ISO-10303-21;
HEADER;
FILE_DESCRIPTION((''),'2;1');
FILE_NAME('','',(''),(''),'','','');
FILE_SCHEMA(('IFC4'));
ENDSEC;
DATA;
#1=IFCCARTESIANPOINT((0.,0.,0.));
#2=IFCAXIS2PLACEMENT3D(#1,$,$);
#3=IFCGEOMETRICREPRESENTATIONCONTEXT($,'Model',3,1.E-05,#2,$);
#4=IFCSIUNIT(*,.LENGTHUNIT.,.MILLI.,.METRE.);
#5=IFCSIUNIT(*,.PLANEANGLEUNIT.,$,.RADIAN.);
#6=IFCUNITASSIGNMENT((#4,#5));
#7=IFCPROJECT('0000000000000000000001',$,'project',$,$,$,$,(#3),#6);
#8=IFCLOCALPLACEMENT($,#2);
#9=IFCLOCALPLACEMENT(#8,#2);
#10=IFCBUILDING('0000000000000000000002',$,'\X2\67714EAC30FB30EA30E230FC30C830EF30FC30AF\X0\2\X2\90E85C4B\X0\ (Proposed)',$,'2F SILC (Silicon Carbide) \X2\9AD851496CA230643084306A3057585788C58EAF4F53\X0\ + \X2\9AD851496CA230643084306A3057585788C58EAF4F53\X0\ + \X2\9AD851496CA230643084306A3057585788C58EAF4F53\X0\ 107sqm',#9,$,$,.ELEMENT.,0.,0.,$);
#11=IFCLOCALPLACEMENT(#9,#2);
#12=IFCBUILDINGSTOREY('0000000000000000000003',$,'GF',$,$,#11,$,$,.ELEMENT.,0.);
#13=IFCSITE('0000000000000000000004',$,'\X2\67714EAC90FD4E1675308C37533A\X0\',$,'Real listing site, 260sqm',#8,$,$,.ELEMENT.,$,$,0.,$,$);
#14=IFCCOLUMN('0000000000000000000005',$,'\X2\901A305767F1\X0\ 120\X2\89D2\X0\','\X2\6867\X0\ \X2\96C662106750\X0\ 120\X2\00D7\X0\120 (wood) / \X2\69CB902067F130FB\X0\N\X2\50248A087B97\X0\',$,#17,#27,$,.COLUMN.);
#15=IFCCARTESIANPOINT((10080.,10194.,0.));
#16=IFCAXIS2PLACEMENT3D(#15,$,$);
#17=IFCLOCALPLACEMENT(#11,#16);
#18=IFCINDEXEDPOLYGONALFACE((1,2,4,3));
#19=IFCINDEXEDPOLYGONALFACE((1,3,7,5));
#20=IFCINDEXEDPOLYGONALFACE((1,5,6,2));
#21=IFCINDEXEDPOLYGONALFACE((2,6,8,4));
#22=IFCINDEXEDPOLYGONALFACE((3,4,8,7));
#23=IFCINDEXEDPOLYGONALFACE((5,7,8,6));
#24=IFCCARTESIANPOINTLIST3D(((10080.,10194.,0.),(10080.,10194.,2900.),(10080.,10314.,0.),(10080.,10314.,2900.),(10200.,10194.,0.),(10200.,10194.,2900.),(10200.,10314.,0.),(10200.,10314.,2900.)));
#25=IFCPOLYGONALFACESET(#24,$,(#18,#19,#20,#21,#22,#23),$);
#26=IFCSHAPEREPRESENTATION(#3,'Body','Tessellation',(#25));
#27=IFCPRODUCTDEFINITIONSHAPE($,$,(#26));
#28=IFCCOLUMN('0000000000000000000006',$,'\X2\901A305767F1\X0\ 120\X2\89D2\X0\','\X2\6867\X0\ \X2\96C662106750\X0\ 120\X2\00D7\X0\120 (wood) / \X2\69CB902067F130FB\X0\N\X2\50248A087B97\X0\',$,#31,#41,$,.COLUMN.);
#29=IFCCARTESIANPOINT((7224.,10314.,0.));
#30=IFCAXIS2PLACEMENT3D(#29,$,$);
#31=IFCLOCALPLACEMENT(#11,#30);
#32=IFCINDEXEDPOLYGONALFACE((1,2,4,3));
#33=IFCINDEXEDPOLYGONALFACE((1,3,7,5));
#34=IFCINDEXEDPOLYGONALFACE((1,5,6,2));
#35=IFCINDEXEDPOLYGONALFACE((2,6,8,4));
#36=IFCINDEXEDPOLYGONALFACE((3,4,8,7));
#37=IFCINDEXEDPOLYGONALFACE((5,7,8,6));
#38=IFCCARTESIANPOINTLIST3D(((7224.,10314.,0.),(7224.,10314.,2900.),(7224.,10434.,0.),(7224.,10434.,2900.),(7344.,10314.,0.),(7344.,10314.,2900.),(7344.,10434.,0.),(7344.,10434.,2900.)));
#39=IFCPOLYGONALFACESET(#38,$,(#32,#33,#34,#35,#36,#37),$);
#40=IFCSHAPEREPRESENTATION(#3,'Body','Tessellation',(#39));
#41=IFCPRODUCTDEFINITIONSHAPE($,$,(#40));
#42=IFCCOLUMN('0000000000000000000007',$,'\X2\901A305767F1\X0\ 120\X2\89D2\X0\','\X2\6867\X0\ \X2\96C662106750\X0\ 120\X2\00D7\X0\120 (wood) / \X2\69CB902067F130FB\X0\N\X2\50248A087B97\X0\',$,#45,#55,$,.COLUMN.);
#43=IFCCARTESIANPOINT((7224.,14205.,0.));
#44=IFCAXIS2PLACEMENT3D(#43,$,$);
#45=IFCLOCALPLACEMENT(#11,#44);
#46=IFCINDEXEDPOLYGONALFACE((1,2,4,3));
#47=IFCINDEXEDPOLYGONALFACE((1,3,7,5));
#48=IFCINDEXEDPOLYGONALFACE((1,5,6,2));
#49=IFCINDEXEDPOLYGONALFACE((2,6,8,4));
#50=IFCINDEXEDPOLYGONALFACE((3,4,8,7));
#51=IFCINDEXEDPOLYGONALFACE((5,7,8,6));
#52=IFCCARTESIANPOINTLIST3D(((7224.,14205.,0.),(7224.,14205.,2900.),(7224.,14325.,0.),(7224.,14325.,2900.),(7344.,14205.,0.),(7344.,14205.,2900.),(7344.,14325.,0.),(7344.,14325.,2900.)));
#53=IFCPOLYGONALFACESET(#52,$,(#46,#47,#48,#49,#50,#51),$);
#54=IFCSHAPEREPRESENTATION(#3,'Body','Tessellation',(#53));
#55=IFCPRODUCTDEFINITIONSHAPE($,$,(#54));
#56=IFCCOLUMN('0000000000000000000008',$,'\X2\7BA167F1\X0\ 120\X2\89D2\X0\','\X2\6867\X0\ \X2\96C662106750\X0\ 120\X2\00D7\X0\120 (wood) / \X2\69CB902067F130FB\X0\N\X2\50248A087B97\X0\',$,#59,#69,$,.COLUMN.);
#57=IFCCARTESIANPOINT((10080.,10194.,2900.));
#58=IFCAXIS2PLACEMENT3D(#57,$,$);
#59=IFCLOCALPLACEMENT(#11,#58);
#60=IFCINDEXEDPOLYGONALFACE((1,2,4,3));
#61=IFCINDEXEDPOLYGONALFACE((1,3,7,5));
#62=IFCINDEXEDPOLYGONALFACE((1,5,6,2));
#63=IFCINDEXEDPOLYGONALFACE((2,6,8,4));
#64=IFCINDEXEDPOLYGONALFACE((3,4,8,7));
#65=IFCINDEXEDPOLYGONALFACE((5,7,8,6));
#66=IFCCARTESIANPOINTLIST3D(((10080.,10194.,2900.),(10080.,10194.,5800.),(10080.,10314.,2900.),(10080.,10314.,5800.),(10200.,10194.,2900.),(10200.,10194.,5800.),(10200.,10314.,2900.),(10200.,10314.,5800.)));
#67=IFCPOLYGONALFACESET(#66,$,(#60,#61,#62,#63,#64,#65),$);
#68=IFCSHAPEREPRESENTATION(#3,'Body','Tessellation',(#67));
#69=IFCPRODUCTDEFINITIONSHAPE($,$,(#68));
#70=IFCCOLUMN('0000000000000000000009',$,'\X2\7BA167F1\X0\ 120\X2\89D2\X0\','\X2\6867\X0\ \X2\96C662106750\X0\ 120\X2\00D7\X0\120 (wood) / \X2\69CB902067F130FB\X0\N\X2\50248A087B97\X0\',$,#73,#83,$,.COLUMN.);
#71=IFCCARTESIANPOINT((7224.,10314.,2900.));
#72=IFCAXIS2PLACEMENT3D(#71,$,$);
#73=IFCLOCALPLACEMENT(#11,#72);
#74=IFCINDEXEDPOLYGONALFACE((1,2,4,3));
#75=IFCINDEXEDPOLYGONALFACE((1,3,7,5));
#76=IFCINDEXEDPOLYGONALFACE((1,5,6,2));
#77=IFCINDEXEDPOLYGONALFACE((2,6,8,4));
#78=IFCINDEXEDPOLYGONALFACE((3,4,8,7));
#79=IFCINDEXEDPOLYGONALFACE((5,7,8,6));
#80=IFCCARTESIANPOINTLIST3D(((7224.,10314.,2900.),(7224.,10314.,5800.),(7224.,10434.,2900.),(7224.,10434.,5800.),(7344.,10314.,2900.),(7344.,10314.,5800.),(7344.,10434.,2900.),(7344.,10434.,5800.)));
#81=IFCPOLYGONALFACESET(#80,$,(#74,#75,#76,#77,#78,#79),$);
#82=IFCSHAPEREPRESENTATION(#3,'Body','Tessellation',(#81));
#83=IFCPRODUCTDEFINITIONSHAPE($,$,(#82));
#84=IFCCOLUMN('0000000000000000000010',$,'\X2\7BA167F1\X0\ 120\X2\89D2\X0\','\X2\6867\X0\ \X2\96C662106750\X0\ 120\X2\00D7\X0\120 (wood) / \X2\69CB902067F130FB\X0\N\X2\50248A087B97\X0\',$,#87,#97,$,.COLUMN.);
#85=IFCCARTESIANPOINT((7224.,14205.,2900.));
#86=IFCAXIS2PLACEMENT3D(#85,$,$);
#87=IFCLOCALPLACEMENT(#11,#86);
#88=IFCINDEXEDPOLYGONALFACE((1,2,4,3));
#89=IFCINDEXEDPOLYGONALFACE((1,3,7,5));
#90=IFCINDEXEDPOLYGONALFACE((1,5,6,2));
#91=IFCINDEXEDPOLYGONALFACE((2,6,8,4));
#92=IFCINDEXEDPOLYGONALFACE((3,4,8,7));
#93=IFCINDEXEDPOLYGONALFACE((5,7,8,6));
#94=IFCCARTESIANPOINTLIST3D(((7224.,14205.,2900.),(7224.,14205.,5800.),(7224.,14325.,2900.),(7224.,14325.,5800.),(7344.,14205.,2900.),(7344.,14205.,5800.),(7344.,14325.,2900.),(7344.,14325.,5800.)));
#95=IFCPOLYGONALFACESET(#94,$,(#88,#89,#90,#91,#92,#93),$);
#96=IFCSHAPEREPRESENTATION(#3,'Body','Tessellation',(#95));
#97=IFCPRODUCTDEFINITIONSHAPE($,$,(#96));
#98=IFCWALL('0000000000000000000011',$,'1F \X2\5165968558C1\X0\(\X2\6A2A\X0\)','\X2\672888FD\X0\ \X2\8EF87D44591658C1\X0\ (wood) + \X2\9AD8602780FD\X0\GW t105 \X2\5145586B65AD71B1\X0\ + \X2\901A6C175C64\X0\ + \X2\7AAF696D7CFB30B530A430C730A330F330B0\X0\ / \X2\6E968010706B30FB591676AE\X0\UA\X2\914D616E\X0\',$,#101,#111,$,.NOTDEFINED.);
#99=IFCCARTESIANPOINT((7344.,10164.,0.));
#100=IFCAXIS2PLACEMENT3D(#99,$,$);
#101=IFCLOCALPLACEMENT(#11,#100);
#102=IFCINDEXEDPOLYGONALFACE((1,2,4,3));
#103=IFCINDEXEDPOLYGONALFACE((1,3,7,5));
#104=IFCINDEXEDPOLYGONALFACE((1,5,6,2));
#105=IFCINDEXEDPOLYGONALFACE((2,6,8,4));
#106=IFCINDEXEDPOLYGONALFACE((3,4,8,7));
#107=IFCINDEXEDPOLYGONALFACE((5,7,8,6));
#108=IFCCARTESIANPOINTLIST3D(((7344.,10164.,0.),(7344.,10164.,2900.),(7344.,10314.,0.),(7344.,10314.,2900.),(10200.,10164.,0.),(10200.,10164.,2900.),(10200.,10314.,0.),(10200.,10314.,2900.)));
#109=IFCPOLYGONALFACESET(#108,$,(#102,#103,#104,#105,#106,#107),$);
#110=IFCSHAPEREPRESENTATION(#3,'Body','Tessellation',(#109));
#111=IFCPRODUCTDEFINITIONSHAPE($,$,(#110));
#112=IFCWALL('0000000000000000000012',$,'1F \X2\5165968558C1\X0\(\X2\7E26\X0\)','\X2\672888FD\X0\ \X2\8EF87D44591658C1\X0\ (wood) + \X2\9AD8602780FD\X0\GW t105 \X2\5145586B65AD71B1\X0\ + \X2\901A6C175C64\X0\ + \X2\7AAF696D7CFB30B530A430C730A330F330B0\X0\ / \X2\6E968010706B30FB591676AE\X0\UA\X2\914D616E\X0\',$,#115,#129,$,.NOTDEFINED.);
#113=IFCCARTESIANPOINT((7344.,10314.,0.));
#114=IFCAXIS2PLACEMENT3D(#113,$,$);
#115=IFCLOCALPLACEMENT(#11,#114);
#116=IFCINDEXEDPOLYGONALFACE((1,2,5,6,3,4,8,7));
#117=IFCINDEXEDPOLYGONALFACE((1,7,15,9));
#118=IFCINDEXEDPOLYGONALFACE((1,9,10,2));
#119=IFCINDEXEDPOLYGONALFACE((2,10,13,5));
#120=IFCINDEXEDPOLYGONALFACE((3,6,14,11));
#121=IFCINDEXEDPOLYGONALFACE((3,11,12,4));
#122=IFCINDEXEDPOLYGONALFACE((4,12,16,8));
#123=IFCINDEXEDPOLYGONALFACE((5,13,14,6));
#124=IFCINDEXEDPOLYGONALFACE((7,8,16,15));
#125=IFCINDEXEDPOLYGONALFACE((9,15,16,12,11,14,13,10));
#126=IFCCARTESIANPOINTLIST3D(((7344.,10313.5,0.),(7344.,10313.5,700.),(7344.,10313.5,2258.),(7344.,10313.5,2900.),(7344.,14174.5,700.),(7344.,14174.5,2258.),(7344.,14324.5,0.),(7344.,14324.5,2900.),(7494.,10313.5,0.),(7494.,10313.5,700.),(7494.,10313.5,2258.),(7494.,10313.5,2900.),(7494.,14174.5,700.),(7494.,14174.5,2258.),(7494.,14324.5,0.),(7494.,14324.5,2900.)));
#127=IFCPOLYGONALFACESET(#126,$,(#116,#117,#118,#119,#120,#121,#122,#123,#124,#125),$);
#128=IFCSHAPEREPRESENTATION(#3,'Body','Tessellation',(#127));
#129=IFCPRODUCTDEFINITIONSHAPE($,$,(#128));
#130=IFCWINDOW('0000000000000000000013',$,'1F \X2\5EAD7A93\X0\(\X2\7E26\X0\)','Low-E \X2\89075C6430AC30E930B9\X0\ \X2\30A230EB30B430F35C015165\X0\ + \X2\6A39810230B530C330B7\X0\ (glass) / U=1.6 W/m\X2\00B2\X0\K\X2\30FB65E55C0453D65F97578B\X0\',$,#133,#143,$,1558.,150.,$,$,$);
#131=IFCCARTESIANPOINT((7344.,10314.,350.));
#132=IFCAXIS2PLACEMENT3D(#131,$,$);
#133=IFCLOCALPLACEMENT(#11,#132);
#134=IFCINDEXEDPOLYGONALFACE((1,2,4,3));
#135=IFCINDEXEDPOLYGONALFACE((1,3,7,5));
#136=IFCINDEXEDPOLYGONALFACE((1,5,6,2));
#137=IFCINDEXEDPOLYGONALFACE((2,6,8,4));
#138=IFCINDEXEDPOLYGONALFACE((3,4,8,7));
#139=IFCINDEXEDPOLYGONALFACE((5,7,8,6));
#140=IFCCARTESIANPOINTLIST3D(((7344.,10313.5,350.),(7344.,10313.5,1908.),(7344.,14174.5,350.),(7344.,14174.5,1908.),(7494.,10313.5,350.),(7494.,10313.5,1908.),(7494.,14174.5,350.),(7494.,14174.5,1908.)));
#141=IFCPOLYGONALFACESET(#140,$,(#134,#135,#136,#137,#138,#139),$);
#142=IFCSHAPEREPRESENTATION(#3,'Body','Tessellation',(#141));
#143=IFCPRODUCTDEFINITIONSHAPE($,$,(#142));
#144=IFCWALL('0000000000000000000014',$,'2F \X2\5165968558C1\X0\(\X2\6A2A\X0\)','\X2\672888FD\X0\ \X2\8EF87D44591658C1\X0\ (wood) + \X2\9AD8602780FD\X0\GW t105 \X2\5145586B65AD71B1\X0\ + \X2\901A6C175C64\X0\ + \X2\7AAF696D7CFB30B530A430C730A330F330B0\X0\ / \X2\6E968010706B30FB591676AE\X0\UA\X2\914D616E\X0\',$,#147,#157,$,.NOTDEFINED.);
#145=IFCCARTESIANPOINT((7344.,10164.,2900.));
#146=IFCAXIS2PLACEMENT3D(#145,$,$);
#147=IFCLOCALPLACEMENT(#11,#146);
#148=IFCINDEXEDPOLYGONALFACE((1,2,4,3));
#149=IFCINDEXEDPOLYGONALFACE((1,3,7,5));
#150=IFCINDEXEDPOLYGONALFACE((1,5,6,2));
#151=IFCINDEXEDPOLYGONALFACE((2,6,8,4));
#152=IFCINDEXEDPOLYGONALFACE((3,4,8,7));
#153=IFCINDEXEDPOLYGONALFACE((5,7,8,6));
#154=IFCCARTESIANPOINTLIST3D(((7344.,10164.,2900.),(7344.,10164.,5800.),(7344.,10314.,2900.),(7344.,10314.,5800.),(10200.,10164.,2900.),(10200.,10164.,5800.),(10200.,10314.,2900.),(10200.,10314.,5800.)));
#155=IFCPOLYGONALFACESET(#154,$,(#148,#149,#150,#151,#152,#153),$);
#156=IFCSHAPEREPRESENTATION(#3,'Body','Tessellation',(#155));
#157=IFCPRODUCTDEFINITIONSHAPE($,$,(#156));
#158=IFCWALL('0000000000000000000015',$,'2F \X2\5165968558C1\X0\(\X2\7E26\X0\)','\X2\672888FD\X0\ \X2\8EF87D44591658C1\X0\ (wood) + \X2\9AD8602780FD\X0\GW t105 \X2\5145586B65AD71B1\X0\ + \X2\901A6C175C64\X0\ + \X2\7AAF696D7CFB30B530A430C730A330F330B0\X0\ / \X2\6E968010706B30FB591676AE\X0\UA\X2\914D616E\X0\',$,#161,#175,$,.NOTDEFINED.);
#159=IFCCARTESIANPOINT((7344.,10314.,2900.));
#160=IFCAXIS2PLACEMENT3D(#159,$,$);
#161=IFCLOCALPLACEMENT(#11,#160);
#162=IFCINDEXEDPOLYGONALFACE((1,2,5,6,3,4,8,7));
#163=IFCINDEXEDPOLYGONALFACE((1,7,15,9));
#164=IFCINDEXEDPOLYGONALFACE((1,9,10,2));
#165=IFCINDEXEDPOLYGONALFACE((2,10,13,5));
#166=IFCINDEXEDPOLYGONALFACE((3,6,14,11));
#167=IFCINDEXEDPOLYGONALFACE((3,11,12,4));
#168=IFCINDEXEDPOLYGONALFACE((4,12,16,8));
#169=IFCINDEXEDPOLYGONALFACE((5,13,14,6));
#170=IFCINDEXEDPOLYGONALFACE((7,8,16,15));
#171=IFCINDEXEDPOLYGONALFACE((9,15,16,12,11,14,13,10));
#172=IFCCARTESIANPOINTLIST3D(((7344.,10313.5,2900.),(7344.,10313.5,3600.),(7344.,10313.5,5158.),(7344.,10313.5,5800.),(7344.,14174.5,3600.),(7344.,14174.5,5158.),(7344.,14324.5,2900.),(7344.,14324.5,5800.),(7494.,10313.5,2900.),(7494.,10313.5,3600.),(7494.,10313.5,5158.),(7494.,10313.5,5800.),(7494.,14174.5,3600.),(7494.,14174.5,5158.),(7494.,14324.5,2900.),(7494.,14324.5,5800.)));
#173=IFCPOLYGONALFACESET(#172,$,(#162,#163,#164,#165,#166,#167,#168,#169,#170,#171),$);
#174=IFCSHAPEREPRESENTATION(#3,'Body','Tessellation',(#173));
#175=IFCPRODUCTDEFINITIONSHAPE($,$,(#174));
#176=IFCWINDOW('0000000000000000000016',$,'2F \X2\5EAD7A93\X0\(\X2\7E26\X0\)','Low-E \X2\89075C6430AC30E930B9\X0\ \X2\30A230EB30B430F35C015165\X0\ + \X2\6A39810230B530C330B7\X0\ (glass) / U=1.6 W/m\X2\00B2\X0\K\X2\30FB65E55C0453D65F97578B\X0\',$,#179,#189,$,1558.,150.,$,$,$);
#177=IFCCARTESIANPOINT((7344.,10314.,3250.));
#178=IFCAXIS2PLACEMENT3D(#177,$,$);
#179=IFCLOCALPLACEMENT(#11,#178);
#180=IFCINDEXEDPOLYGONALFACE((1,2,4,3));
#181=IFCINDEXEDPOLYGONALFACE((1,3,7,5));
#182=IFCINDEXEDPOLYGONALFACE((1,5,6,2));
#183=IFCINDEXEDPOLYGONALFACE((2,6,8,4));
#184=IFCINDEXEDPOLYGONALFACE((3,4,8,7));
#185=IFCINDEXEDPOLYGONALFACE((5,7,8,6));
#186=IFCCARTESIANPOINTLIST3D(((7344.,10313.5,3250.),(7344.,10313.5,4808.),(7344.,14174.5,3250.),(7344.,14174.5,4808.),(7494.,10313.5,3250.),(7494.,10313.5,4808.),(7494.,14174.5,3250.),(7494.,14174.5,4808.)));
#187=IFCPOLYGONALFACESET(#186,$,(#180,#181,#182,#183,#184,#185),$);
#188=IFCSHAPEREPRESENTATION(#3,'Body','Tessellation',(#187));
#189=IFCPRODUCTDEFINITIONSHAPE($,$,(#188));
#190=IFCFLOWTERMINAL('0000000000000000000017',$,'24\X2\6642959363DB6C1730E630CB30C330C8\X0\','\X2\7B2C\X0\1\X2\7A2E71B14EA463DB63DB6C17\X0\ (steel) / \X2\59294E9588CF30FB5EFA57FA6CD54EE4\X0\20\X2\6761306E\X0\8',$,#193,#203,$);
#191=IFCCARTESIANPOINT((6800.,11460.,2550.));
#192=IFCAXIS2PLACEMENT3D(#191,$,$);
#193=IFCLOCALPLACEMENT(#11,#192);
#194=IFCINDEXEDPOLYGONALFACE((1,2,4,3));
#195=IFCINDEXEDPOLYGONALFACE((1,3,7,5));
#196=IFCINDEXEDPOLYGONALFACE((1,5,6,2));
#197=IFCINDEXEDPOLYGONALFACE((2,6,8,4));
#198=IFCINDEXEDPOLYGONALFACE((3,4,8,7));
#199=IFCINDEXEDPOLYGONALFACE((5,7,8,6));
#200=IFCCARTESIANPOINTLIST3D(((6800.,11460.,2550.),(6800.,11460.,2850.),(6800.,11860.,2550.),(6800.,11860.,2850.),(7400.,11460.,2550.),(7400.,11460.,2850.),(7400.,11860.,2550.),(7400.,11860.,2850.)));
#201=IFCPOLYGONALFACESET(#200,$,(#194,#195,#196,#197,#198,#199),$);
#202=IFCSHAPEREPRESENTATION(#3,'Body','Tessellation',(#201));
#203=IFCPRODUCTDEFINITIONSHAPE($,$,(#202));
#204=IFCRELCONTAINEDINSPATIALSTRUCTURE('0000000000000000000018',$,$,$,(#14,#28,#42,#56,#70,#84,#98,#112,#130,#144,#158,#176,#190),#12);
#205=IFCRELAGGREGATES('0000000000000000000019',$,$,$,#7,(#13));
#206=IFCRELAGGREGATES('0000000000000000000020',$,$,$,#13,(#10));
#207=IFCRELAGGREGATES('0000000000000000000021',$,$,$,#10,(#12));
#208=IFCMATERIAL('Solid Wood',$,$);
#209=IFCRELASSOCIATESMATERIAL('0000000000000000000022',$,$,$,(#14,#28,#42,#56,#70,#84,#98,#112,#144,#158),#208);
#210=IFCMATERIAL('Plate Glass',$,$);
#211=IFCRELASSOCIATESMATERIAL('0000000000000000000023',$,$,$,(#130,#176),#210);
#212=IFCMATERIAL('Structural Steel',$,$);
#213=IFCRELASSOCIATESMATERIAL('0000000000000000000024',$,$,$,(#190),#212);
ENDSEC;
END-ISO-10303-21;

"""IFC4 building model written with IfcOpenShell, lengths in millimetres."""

from ifc_helpers import new_model, si_unit, frame, frame_2d, origin, place, context, project, spatial, rectangle, extrude, material, element, fill, save


model = new_model("IFC4")

# Units and contexts
model_context = context("Model", 3, precision=1e-05, world=origin())
ifc_project = project(units=[si_unit("LENGTHUNIT", "METRE", prefix="MILLI"), si_unit("PLANEANGLEUNIT", "RADIAN")], contexts=[model_context])

# Site, building, storey
site_placement = place(None, origin())
site = spatial("IfcSite", under=ifc_project, at=site_placement, Name="東京都世田谷区", ObjectType="Real listing site, 260sqm", CompositionType="ELEMENT", RefElevation=0.0)
building_placement = place(site_placement, origin())
building = spatial("IfcBuilding", under=site, at=building_placement, Name="東京・リモートワーク2部屋 (Proposed)", ObjectType="2F SILC (Silicon Carbide) 高光沢つやなし塗装躯体 + 高光沢つやなし塗装躯体 + 高光沢つやなし塗装躯体 107sqm", CompositionType="ELEMENT", ElevationOfRefHeight=0.0, ElevationOfTerrain=0.0)
storey_placement = place(building_placement, origin())
storey = spatial("IfcBuildingStorey", under=building, at=storey_placement, Name="GF", CompositionType="ELEMENT", Elevation=0.0)

# Columns
ifc_material_1 = material(Name="Solid Wood")
column_1_placement = place(storey_placement, frame((10080.0, 10194.0, 0.0)))
element("IfcColumn", 1, at=column_1_placement, inside=storey, material=ifc_material_1, Name="通し柱 120角", Description="桧 集成材 120×120 (wood) / 構造柱・N値計算", PredefinedType="COLUMN", context=model_context, shape_type="SweptSolid", body=[
    extrude(rectangle(XDim=120.0, YDim=120.0, at=frame_2d((60.0, 60.0))), frame((10080.0, 10194.0, 0.0)), (0.0, 0.0, 1.0), 2900.0),
])
column_2_placement = place(storey_placement, frame((7224.0, 10314.0, 0.0)))
element("IfcColumn", 2, at=column_2_placement, inside=storey, material=ifc_material_1, Name="通し柱 120角", Description="桧 集成材 120×120 (wood) / 構造柱・N値計算", PredefinedType="COLUMN", context=model_context, shape_type="SweptSolid", body=[
    extrude(rectangle(XDim=120.0, YDim=120.0, at=frame_2d((60.0, 60.0))), frame((7224.0, 10314.0, 0.0)), (0.0, 0.0, 1.0), 2900.0),
])
column_3_placement = place(storey_placement, frame((7224.0, 14205.0, 0.0)))
element("IfcColumn", 3, at=column_3_placement, inside=storey, material=ifc_material_1, Name="通し柱 120角", Description="桧 集成材 120×120 (wood) / 構造柱・N値計算", PredefinedType="COLUMN", context=model_context, shape_type="SweptSolid", body=[
    extrude(rectangle(XDim=120.0, YDim=120.0, at=frame_2d((60.0, 60.0))), frame((7224.0, 14205.0, 0.0)), (0.0, 0.0, 1.0), 2900.0),
])
column_4_placement = place(storey_placement, frame((10080.0, 10194.0, 2900.0)))
element("IfcColumn", 4, at=column_4_placement, inside=storey, material=ifc_material_1, Name="管柱 120角", Description="桧 集成材 120×120 (wood) / 構造柱・N値計算", PredefinedType="COLUMN", context=model_context, shape_type="SweptSolid", body=[
    extrude(rectangle(XDim=120.0, YDim=120.0, at=frame_2d((60.0, 60.0))), frame((10080.0, 10194.0, 2900.0)), (0.0, 0.0, 1.0), 2900.0),
])
column_5_placement = place(storey_placement, frame((7224.0, 10314.0, 2900.0)))
element("IfcColumn", 5, at=column_5_placement, inside=storey, material=ifc_material_1, Name="管柱 120角", Description="桧 集成材 120×120 (wood) / 構造柱・N値計算", PredefinedType="COLUMN", context=model_context, shape_type="SweptSolid", body=[
    extrude(rectangle(XDim=120.0, YDim=120.0, at=frame_2d((60.0, 60.0))), frame((7224.0, 10314.0, 2900.0)), (0.0, 0.0, 1.0), 2900.0),
])
column_6_placement = place(storey_placement, frame((7224.0, 14205.0, 2900.0)))
element("IfcColumn", 6, at=column_6_placement, inside=storey, material=ifc_material_1, Name="管柱 120角", Description="桧 集成材 120×120 (wood) / 構造柱・N値計算", PredefinedType="COLUMN", context=model_context, shape_type="SweptSolid", body=[
    extrude(rectangle(XDim=120.0, YDim=120.0, at=frame_2d((60.0, 60.0))), frame((7224.0, 14205.0, 2900.0)), (0.0, 0.0, 1.0), 2900.0),
])

# Wall
wall_1_placement = place(storey_placement, frame((7344.0, 10164.0, 0.0)))
element("IfcWall", 7, at=wall_1_placement, inside=storey, material=ifc_material_1, Name="1F 入隅壁(横)", Description="木製 軸組外壁 (wood) + 高性能GW t105 充填断熱 + 通気層 + 窯業系サイディング / 準耐火・外皮UA配慮", PredefinedType="NOTDEFINED", context=model_context, shape_type="SweptSolid", body=[
    extrude(rectangle(XDim=2856.0, YDim=150.0, at=frame_2d((1428.0, 75.0))), frame((7344.0, 10164.0, 0.0)), (0.0, 0.0, 1.0), 2900.0),
])

# Wall, opening, window
wall_2_placement = place(storey_placement, frame((7344.0, 10314.0, 0.0)))
wall_2 = element("IfcWall", 8, at=wall_2_placement, inside=storey, material=ifc_material_1, Name="1F 入隅壁(縦)", Description="木製 軸組外壁 (wood) + 高性能GW t105 充填断熱 + 通気層 + 窯業系サイディング / 準耐火・外皮UA配慮", PredefinedType="NOTDEFINED", context=model_context, shape_type="SweptSolid", body=[
    extrude(rectangle(XDim=150.0, YDim=4011.0, at=frame_2d((75.0, 2005.0))), frame((7344.0, 10314.0, 0.0)), (0.0, 0.0, 1.0), 2900.0),
])
opening_1_placement = place(storey_placement, frame((7344.0, 10314.0, 350.0)))
opening_1 = element("IfcOpeningElement", 9, at=opening_1_placement, cuts=wall_2, PredefinedType="NOTDEFINED", context=model_context, shape_type="SweptSolid", body=[
    extrude(rectangle(XDim=150.0, YDim=3861.0, at=frame_2d((75.0, 1930.0))), frame((7344.0, 10314.0, 350.0)), (0.0, 0.0, 1.0), 1558.0),
])
ifc_material_2 = material(Name="Plate Glass")
window_1_placement = place(storey_placement, frame((7344.0, 10314.0, 350.0)))
window_1 = element("IfcWindow", 10, at=window_1_placement, inside=storey, material=ifc_material_2, Name="1F 庭窓(縦)", Description="Low-E 複層ガラス アルゴン封入 + 樹脂サッシ (glass) / U=1.6 W/m²K・日射取得型", OverallHeight=1558.0, OverallWidth=150.0, context=model_context, shape_type="SweptSolid", body=[
    extrude(rectangle(XDim=150.0, YDim=3861.0, at=frame_2d((75.0, 1930.0))), frame((7344.0, 10314.0, 350.0)), (0.0, 0.0, 1.0), 1558.0),
])
fill(opening_1, window_1)

# Wall
wall_3_placement = place(storey_placement, frame((7344.0, 10164.0, 2900.0)))
element("IfcWall", 11, at=wall_3_placement, inside=storey, material=ifc_material_1, Name="2F 入隅壁(横)", Description="木製 軸組外壁 (wood) + 高性能GW t105 充填断熱 + 通気層 + 窯業系サイディング / 準耐火・外皮UA配慮", PredefinedType="NOTDEFINED", context=model_context, shape_type="SweptSolid", body=[
    extrude(rectangle(XDim=2856.0, YDim=150.0, at=frame_2d((1428.0, 75.0))), frame((7344.0, 10164.0, 2900.0)), (0.0, 0.0, 1.0), 2900.0),
])

# Wall, opening, window
wall_4_placement = place(storey_placement, frame((7344.0, 10314.0, 2900.0)))
wall_4 = element("IfcWall", 12, at=wall_4_placement, inside=storey, material=ifc_material_1, Name="2F 入隅壁(縦)", Description="木製 軸組外壁 (wood) + 高性能GW t105 充填断熱 + 通気層 + 窯業系サイディング / 準耐火・外皮UA配慮", PredefinedType="NOTDEFINED", context=model_context, shape_type="SweptSolid", body=[
    extrude(rectangle(XDim=150.0, YDim=4011.0, at=frame_2d((75.0, 2005.0))), frame((7344.0, 10314.0, 2900.0)), (0.0, 0.0, 1.0), 2900.0),
])
opening_2_placement = place(storey_placement, frame((7344.0, 10314.0, 3250.0)))
opening_2 = element("IfcOpeningElement", 13, at=opening_2_placement, cuts=wall_4, PredefinedType="NOTDEFINED", context=model_context, shape_type="SweptSolid", body=[
    extrude(rectangle(XDim=150.0, YDim=3861.0, at=frame_2d((75.0, 1930.0))), frame((7344.0, 10314.0, 3250.0)), (0.0, 0.0, 1.0), 1558.0),
])
window_2_placement = place(storey_placement, frame((7344.0, 10314.0, 3250.0)))
window_2 = element("IfcWindow", 14, at=window_2_placement, inside=storey, material=ifc_material_2, Name="2F 庭窓(縦)", Description="Low-E 複層ガラス アルゴン封入 + 樹脂サッシ (glass) / U=1.6 W/m²K・日射取得型", OverallHeight=1558.0, OverallWidth=150.0, context=model_context, shape_type="SweptSolid", body=[
    extrude(rectangle(XDim=150.0, YDim=3861.0, at=frame_2d((75.0, 1930.0))), frame((7344.0, 10314.0, 3250.0)), (0.0, 0.0, 1.0), 1558.0),
])
fill(opening_2, window_2)

# Flow terminal
ifc_material_3 = material(Name="Structural Steel")
flow_terminal_placement = place(storey_placement, frame((6800.0, 11460.0, 2550.0)))
element("IfcFlowTerminal", 15, at=flow_terminal_placement, inside=storey, material=ifc_material_3, Name="24時間換気ユニット", Description="第1種熱交換換気 (steel) / 天井裏・建基法令20条の8", context=model_context, shape_type="SweptSolid", body=[
    extrude(rectangle(XDim=600.0, YDim=400.0, at=frame_2d((300.0, 200.0))), frame((6800.0, 11460.0, 2550.0)), (0.0, 0.0, 1.0), 300.0),
])

save(model, "model.ifc")
